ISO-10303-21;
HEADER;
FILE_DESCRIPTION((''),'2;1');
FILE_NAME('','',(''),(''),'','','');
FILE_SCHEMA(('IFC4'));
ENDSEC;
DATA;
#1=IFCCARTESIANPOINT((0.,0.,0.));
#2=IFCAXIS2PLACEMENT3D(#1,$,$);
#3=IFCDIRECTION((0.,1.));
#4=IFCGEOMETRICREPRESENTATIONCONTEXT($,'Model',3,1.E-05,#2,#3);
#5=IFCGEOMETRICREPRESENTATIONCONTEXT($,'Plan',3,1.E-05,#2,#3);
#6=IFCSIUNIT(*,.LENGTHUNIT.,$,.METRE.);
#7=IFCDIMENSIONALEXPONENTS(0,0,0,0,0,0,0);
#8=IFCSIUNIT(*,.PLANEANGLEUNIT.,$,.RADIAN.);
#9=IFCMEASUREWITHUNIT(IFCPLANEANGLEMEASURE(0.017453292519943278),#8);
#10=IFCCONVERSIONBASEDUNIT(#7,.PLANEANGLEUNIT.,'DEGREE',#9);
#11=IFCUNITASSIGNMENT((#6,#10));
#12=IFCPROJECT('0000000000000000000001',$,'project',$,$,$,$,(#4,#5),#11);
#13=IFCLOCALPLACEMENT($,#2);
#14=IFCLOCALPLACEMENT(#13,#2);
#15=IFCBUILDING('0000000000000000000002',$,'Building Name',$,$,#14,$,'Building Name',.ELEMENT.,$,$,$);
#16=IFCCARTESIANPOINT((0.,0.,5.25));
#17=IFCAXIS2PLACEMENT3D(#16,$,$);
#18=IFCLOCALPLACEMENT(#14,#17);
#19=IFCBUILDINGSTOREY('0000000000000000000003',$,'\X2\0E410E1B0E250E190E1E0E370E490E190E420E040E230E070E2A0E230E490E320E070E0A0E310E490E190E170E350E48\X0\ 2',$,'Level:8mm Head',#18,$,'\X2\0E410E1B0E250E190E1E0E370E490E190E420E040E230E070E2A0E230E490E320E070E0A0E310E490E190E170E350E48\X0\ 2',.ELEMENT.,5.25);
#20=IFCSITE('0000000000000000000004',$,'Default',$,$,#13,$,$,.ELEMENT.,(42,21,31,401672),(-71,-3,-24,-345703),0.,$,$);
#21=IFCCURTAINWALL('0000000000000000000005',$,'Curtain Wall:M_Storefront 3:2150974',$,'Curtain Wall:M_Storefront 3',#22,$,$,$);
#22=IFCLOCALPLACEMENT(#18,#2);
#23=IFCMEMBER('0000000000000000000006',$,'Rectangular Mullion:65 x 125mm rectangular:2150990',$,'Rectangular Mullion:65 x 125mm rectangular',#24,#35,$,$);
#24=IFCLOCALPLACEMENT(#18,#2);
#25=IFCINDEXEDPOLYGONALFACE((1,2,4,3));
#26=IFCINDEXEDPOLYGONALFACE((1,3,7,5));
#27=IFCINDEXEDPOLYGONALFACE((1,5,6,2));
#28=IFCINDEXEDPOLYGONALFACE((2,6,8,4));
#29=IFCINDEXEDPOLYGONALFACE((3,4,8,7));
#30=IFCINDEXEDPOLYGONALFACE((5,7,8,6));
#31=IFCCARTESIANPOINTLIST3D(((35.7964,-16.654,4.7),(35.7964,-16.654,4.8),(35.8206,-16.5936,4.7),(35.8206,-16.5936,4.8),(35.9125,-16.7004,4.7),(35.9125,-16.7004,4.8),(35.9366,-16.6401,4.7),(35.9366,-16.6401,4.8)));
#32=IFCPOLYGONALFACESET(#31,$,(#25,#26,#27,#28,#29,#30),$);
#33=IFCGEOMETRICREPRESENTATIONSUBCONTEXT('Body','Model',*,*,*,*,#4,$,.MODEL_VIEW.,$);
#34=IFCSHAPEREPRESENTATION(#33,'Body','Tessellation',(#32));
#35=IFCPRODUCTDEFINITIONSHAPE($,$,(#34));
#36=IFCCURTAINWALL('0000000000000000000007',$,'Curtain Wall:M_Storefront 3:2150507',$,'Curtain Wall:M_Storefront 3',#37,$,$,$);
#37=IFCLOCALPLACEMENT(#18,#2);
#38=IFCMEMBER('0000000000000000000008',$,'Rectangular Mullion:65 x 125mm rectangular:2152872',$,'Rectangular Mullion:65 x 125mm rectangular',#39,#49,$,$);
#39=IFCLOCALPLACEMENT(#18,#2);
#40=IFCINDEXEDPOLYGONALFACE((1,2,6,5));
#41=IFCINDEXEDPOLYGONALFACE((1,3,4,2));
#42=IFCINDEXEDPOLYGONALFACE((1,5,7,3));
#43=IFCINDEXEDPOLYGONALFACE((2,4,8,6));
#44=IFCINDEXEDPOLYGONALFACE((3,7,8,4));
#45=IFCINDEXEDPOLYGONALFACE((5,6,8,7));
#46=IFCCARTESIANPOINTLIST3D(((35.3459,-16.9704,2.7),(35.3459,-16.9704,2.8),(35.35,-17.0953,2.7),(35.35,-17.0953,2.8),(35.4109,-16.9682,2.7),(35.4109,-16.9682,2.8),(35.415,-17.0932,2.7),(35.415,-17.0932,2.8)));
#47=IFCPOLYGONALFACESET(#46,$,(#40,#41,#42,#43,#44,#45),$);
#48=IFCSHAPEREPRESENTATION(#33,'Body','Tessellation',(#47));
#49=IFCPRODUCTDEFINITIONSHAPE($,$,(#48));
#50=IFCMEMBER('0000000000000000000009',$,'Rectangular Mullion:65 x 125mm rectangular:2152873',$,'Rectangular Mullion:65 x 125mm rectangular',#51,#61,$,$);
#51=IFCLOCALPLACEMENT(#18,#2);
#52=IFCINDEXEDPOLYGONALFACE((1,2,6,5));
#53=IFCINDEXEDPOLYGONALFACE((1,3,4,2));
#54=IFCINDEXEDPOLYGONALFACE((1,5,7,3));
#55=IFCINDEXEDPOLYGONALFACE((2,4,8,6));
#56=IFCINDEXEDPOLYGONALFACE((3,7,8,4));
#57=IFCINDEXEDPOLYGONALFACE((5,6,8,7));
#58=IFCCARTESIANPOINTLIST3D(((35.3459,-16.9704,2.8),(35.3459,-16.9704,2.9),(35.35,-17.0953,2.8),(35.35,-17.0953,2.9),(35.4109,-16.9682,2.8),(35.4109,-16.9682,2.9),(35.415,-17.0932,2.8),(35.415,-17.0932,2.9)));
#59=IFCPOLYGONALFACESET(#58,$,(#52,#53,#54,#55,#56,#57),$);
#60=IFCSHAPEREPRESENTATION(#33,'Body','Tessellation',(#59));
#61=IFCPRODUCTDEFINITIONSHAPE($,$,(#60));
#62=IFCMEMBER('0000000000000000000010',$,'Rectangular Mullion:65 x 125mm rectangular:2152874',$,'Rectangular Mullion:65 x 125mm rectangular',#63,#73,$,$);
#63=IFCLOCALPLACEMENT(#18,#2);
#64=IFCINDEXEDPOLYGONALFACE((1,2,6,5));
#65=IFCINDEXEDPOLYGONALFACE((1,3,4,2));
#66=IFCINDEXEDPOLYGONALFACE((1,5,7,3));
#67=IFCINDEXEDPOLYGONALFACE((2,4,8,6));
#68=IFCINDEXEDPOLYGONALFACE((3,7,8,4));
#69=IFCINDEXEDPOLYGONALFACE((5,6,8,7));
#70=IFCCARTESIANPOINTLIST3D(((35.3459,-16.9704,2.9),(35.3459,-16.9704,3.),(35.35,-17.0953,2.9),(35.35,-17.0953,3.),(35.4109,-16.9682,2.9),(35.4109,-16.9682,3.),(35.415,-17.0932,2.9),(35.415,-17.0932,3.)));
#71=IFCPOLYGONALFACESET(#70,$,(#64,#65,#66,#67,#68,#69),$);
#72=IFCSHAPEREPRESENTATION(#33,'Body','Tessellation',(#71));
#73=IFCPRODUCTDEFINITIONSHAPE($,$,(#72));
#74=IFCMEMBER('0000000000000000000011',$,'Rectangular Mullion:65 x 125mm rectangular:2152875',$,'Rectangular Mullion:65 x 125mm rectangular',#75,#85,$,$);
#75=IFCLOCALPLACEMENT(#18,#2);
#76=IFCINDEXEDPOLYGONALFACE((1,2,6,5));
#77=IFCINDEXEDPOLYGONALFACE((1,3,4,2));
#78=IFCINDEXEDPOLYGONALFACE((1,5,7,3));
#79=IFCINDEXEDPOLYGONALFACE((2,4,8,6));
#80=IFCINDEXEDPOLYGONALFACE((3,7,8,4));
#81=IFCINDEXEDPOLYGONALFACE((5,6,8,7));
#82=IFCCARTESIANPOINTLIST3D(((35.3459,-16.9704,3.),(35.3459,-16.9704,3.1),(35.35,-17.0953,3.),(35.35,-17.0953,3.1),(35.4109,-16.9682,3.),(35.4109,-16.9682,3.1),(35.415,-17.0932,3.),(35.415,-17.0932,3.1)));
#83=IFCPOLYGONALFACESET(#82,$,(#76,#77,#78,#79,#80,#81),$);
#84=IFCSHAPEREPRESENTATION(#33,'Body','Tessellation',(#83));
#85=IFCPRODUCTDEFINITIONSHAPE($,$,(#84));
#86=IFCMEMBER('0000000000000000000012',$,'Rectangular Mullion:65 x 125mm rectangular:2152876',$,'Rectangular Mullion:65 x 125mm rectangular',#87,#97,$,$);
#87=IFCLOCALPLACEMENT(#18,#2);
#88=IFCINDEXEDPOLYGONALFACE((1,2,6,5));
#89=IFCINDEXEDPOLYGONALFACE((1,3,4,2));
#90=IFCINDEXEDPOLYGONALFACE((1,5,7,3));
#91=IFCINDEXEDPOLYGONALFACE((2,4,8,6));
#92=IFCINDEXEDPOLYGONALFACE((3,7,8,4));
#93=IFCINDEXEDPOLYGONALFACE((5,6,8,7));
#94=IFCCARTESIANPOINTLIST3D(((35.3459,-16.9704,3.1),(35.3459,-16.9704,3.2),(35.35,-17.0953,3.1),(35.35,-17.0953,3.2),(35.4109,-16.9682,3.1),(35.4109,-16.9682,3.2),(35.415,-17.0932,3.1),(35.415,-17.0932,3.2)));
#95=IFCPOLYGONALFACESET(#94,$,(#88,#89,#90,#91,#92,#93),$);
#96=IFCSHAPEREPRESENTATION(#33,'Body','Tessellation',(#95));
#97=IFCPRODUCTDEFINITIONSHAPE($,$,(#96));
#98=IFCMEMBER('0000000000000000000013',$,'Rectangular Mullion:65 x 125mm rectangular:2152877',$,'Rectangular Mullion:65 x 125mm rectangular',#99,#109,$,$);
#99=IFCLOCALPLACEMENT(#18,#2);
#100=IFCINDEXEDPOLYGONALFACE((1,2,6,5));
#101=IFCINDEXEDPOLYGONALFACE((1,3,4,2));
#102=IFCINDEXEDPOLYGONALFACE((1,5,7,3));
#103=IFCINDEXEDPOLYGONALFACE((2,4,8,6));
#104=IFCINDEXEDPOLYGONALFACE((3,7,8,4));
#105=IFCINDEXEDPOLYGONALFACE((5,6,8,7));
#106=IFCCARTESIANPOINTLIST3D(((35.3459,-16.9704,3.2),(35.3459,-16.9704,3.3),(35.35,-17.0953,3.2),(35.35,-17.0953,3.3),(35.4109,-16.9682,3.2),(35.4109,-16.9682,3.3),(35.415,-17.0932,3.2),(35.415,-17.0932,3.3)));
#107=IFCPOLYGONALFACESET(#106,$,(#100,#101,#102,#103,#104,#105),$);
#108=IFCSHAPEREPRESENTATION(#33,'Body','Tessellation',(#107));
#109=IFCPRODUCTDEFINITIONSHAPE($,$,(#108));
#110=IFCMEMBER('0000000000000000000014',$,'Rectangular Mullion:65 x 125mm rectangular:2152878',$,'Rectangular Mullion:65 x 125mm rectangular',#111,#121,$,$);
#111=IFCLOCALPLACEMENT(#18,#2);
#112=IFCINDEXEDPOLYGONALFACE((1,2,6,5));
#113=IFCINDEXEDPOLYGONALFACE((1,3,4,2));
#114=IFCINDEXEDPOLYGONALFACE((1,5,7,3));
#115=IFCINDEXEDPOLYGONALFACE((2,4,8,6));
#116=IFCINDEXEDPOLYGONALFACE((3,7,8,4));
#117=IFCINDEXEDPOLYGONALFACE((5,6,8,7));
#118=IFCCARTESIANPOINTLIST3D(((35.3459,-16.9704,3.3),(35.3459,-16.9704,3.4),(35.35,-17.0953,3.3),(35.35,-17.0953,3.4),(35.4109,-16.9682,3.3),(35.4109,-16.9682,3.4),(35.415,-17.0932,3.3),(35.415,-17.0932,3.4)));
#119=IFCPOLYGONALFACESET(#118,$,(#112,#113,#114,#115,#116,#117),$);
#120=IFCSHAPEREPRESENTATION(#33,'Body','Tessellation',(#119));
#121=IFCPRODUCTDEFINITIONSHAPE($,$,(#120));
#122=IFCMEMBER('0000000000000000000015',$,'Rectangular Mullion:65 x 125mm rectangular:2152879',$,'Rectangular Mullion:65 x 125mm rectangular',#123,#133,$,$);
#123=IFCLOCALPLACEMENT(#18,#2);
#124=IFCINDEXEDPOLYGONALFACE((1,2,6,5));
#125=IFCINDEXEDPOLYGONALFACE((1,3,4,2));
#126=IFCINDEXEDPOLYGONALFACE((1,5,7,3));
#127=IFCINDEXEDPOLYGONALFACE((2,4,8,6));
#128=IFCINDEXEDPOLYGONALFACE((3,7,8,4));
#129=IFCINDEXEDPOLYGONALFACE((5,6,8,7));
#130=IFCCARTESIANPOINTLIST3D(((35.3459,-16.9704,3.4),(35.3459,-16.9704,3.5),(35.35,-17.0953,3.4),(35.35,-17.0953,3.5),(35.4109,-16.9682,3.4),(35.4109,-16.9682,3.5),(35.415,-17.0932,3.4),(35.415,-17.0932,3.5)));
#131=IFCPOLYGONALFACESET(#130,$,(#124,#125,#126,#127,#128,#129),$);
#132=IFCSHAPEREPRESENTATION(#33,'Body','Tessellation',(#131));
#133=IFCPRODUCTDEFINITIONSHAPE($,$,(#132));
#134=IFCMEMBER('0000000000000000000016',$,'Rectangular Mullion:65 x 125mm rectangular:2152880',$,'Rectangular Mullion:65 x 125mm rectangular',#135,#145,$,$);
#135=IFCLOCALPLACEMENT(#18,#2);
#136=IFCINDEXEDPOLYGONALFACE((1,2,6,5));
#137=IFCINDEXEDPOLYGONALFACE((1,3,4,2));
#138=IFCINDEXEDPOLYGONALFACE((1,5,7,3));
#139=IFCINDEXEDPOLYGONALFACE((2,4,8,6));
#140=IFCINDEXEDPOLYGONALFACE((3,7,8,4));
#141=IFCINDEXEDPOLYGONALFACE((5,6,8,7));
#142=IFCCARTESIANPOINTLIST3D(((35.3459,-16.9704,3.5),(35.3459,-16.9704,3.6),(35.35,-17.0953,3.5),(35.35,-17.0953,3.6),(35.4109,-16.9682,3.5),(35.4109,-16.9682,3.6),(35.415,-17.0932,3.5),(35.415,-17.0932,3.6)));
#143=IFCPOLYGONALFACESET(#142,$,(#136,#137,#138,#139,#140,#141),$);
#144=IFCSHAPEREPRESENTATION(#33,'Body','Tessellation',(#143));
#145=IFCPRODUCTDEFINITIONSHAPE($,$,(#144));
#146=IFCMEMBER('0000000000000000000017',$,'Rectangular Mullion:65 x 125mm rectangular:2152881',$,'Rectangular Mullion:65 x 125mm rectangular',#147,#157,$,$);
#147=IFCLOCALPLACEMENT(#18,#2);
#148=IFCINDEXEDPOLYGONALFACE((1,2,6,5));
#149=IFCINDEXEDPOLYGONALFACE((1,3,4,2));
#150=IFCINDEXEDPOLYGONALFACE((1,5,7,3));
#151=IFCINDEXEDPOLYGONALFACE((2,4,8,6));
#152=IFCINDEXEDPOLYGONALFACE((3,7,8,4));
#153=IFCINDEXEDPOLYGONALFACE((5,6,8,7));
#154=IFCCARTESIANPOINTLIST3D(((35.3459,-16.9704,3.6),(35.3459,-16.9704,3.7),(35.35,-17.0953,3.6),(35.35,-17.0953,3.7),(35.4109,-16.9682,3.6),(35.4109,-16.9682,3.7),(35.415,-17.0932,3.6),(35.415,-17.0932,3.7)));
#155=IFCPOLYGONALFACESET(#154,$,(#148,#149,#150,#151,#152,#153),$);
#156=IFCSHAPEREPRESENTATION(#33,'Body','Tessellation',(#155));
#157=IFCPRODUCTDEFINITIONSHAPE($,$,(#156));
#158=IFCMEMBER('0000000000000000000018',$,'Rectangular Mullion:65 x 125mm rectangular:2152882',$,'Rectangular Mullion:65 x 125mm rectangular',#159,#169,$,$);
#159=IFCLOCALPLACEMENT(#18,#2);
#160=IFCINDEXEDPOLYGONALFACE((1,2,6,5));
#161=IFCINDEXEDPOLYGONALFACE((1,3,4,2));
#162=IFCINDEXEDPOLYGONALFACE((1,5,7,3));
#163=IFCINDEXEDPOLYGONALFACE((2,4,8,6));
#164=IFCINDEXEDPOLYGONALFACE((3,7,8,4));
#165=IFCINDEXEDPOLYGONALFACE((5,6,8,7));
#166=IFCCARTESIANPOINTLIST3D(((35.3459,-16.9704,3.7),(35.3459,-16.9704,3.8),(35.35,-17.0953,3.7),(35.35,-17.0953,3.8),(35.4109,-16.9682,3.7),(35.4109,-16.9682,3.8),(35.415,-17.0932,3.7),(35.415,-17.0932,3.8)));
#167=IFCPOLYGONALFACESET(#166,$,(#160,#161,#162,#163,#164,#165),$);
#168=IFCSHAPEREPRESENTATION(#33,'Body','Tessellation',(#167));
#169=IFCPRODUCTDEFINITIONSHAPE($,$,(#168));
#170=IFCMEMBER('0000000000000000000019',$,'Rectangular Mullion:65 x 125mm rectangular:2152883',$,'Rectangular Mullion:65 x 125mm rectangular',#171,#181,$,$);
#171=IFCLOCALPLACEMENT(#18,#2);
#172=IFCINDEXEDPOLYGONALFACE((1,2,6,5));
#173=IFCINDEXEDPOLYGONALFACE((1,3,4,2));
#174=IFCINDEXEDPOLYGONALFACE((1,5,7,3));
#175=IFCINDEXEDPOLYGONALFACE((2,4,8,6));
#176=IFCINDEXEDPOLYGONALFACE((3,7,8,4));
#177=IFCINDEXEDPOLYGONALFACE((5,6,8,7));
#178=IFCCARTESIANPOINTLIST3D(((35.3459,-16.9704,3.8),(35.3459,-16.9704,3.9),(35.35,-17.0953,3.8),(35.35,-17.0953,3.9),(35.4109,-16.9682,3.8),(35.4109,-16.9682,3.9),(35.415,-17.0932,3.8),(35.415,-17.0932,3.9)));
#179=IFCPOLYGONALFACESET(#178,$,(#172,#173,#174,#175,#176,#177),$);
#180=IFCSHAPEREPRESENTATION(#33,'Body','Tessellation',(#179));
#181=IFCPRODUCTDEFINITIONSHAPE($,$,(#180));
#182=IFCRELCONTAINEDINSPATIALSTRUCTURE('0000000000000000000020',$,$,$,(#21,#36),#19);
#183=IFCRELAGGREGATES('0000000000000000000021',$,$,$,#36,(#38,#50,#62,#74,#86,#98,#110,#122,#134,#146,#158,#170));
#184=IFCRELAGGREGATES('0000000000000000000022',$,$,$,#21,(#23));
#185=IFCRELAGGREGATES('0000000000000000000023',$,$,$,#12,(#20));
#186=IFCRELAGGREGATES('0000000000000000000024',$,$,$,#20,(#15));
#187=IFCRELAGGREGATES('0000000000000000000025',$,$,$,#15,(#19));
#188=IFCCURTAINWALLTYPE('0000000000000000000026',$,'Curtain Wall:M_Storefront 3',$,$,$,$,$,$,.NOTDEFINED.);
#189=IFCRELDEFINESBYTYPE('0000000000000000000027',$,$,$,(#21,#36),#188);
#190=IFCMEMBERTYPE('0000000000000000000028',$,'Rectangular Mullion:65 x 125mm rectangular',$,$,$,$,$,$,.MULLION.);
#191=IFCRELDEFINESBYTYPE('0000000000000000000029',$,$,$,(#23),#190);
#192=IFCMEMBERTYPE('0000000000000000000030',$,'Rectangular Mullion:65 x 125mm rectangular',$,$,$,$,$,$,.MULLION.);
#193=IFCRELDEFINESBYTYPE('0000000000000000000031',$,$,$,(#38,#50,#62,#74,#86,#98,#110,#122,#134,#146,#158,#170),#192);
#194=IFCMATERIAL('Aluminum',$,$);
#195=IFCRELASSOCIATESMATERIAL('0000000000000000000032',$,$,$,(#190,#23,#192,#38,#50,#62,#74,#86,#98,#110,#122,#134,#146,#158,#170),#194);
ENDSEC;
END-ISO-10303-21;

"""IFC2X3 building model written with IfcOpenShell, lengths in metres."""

from ifc_helpers import new_model, entity, si_unit, converted_unit, direction, frame, origin, origin_2d_with_axis, place, context, subcontext, project, spatial, rectangle, extrude, source, transform, mapped, material, type_object, type_shapes, element, aggregate, save


model = new_model("IFC2X3")

# Units and contexts
model_context = context("Model", 3, precision=1e-05, world=origin(), true_north=direction((0.0, 1.0)))
plan_context = context("Plan", 3, precision=1e-05, world=origin(), true_north=direction((0.0, 1.0)))
body_context = subcontext(model_context, "Body", "Model", "MODEL_VIEW")
ifc_project = project(units=[si_unit("LENGTHUNIT", "METRE"), converted_unit("PLANEANGLEUNIT", "DEGREE", entity("IfcPlaneAngleMeasure", 0.017453292519943278), si_unit("PLANEANGLEUNIT", "RADIAN"), dimensions=[0, 0, 0, 0, 0, 0, 0])], contexts=[model_context, plan_context])

# Site, building, storey
site_placement = place(None, origin())
site = spatial("IfcSite", under=ifc_project, at=site_placement, Name="Default", CompositionType="ELEMENT", RefLatitude=(42, 21, 31, 401672), RefLongitude=(-71, -3, -24, -345703), RefElevation=0.0)
building_placement = place(site_placement, origin())
building = spatial("IfcBuilding", under=site, at=building_placement, Name="Building Name", LongName="Building Name", CompositionType="ELEMENT")
storey_placement = place(building_placement, frame((0.0, 0.0, 5.25)))
storey = spatial("IfcBuildingStorey", under=building, at=storey_placement, Name="แปลนพื้นโครงสร้างชั้นที่ 2", ObjectType="Level:8mm Head", LongName="แปลนพื้นโครงสร้างชั้นที่ 2", CompositionType="ELEMENT", Elevation=5.25)

# Curtain wall, member
curtain_wall_type = type_object("IfcCurtainWallType", Name="Curtain Wall:M_Storefront 3", PredefinedType="NOTDEFINED")
curtain_wall_1_placement = place(storey_placement, frame((0.0, 0.0, -5.25)))
curtain_wall_1 = element("IfcCurtainWall", 1, at=curtain_wall_1_placement, inside=storey, type_object=curtain_wall_type, Name="Curtain Wall:M_Storefront 3:2150974", ObjectType="Curtain Wall:M_Storefront 3")
ifc_material = material(Name="Aluminum")
member_type_1 = type_object("IfcMemberType", Name="Rectangular Mullion:65 x 125mm rectangular", PredefinedType="MULLION", material=ifc_material)
shared_shape_1 = source(origin(), body_context, "Body", "SweptSolid", [
    extrude(rectangle(XDim=0.065, YDim=0.125, at=origin_2d_with_axis()), frame((-0.0325, 0.0, -0.1), z_axis=(0.0, 0.0, 1.0), x_axis=(-1.0, 0.0, 0.0)), (0.0, 0.0, 1.0), 0.1),
])
type_shapes(member_type_1, [shared_shape_1])
member_1_placement = place(curtain_wall_1_placement, frame((35.8545, -16.6772, 10.05), z_axis=(0.0, 0.0, 1.0), x_axis=(-0.371573, -0.928404, 0.0)))
member_1 = element("IfcMember", 2, at=member_1_placement, type_object=member_type_1, material=ifc_material, Name="Rectangular Mullion:65 x 125mm rectangular:2150990", ObjectType="Rectangular Mullion:65 x 125mm rectangular", context=body_context, shape_type="MappedRepresentation", body=[
    mapped(shared_shape_1, transform((0.0, 0.0, 0.0), scale=1.0)),
])

# Curtain wall, members
curtain_wall_2_placement = place(storey_placement, frame((0.0, 0.0, -5.25)))
curtain_wall_2 = element("IfcCurtainWall", 3, at=curtain_wall_2_placement, inside=storey, type_object=curtain_wall_type, Name="Curtain Wall:M_Storefront 3:2150507", ObjectType="Curtain Wall:M_Storefront 3")
member_type_2 = type_object("IfcMemberType", Name="Rectangular Mullion:65 x 125mm rectangular", PredefinedType="MULLION", material=ifc_material)
shared_shape_2 = source(origin(), body_context, "Body", "SweptSolid", [
    extrude(rectangle(XDim=0.065, YDim=0.125, at=origin_2d_with_axis()), frame((-0.0325, 0.0, -0.1), z_axis=(0.0, 0.0, 1.0), x_axis=(-1.0, 0.0, 0.0)), (0.0, 0.0, 1.0), 0.1),
])
type_shapes(member_type_2, [shared_shape_2])
member_2_placement = place(curtain_wall_2_placement, frame((35.4129, -17.0307, 7.95), z_axis=(0.0, 0.0, -1.0), x_axis=(0.99946, 0.032862, 0.0)))
member_2 = element("IfcMember", 4, at=member_2_placement, type_object=member_type_2, material=ifc_material, Name="Rectangular Mullion:65 x 125mm rectangular:2152872", ObjectType="Rectangular Mullion:65 x 125mm rectangular", context=body_context, shape_type="MappedRepresentation", body=[
    mapped(shared_shape_2, transform((0.0, 0.0, 0.0), scale=1.0)),
])
member_3_placement = place(curtain_wall_2_placement, frame((35.4129, -17.0307, 8.05), z_axis=(0.0, 0.0, -1.0), x_axis=(0.99946, 0.032862, 0.0)))
member_3 = element("IfcMember", 5, at=member_3_placement, type_object=member_type_2, material=ifc_material, Name="Rectangular Mullion:65 x 125mm rectangular:2152873", ObjectType="Rectangular Mullion:65 x 125mm rectangular", context=body_context, shape_type="MappedRepresentation", body=[
    mapped(shared_shape_2, transform((0.0, 0.0, 0.0), scale=1.0)),
])
member_4_placement = place(curtain_wall_2_placement, frame((35.4129, -17.0307, 8.15), z_axis=(0.0, 0.0, -1.0), x_axis=(0.99946, 0.032862, 0.0)))
member_4 = element("IfcMember", 6, at=member_4_placement, type_object=member_type_2, material=ifc_material, Name="Rectangular Mullion:65 x 125mm rectangular:2152874", ObjectType="Rectangular Mullion:65 x 125mm rectangular", context=body_context, shape_type="MappedRepresentation", body=[
    mapped(shared_shape_2, transform((0.0, 0.0, 0.0), scale=1.0)),
])
member_5_placement = place(curtain_wall_2_placement, frame((35.4129, -17.0307, 8.25), z_axis=(0.0, 0.0, -1.0), x_axis=(0.99946, 0.032862, 0.0)))
member_5 = element("IfcMember", 7, at=member_5_placement, type_object=member_type_2, material=ifc_material, Name="Rectangular Mullion:65 x 125mm rectangular:2152875", ObjectType="Rectangular Mullion:65 x 125mm rectangular", context=body_context, shape_type="MappedRepresentation", body=[
    mapped(shared_shape_2, transform((0.0, 0.0, 0.0), scale=1.0)),
])
member_6_placement = place(curtain_wall_2_placement, frame((35.4129, -17.0307, 8.35), z_axis=(0.0, 0.0, -1.0), x_axis=(0.99946, 0.032862, 0.0)))
member_6 = element("IfcMember", 8, at=member_6_placement, type_object=member_type_2, material=ifc_material, Name="Rectangular Mullion:65 x 125mm rectangular:2152876", ObjectType="Rectangular Mullion:65 x 125mm rectangular", context=body_context, shape_type="MappedRepresentation", body=[
    mapped(shared_shape_2, transform((0.0, 0.0, 0.0), scale=1.0)),
])
member_7_placement = place(curtain_wall_2_placement, frame((35.4129, -17.0307, 8.45), z_axis=(0.0, 0.0, -1.0), x_axis=(0.99946, 0.032862, 0.0)))
member_7 = element("IfcMember", 9, at=member_7_placement, type_object=member_type_2, material=ifc_material, Name="Rectangular Mullion:65 x 125mm rectangular:2152877", ObjectType="Rectangular Mullion:65 x 125mm rectangular", context=body_context, shape_type="MappedRepresentation", body=[
    mapped(shared_shape_2, transform((0.0, 0.0, 0.0), scale=1.0)),
])
member_8_placement = place(curtain_wall_2_placement, frame((35.4129, -17.0307, 8.55), z_axis=(0.0, 0.0, -1.0), x_axis=(0.99946, 0.032862, 0.0)))
member_8 = element("IfcMember", 10, at=member_8_placement, type_object=member_type_2, material=ifc_material, Name="Rectangular Mullion:65 x 125mm rectangular:2152878", ObjectType="Rectangular Mullion:65 x 125mm rectangular", context=body_context, shape_type="MappedRepresentation", body=[
    mapped(shared_shape_2, transform((0.0, 0.0, 0.0), scale=1.0)),
])
member_9_placement = place(curtain_wall_2_placement, frame((35.4129, -17.0307, 8.65), z_axis=(0.0, 0.0, -1.0), x_axis=(0.99946, 0.032862, 0.0)))
member_9 = element("IfcMember", 11, at=member_9_placement, type_object=member_type_2, material=ifc_material, Name="Rectangular Mullion:65 x 125mm rectangular:2152879", ObjectType="Rectangular Mullion:65 x 125mm rectangular", context=body_context, shape_type="MappedRepresentation", body=[
    mapped(shared_shape_2, transform((0.0, 0.0, 0.0), scale=1.0)),
])
member_10_placement = place(curtain_wall_2_placement, frame((35.4129, -17.0307, 8.75), z_axis=(0.0, 0.0, -1.0), x_axis=(0.99946, 0.032862, 0.0)))
member_10 = element("IfcMember", 12, at=member_10_placement, type_object=member_type_2, material=ifc_material, Name="Rectangular Mullion:65 x 125mm rectangular:2152880", ObjectType="Rectangular Mullion:65 x 125mm rectangular", context=body_context, shape_type="MappedRepresentation", body=[
    mapped(shared_shape_2, transform((0.0, 0.0, 0.0), scale=1.0)),
])
member_11_placement = place(curtain_wall_2_placement, frame((35.4129, -17.0307, 8.85), z_axis=(0.0, 0.0, -1.0), x_axis=(0.99946, 0.032862, 0.0)))
member_11 = element("IfcMember", 13, at=member_11_placement, type_object=member_type_2, material=ifc_material, Name="Rectangular Mullion:65 x 125mm rectangular:2152881", ObjectType="Rectangular Mullion:65 x 125mm rectangular", context=body_context, shape_type="MappedRepresentation", body=[
    mapped(shared_shape_2, transform((0.0, 0.0, 0.0), scale=1.0)),
])
member_12_placement = place(curtain_wall_2_placement, frame((35.4129, -17.0307, 8.95), z_axis=(0.0, 0.0, -1.0), x_axis=(0.99946, 0.032862, 0.0)))
member_12 = element("IfcMember", 14, at=member_12_placement, type_object=member_type_2, material=ifc_material, Name="Rectangular Mullion:65 x 125mm rectangular:2152882", ObjectType="Rectangular Mullion:65 x 125mm rectangular", context=body_context, shape_type="MappedRepresentation", body=[
    mapped(shared_shape_2, transform((0.0, 0.0, 0.0), scale=1.0)),
])
member_13_placement = place(curtain_wall_2_placement, frame((35.4129, -17.0307, 9.05), z_axis=(0.0, 0.0, -1.0), x_axis=(0.99946, 0.032862, 0.0)))
member_13 = element("IfcMember", 15, at=member_13_placement, type_object=member_type_2, material=ifc_material, Name="Rectangular Mullion:65 x 125mm rectangular:2152883", ObjectType="Rectangular Mullion:65 x 125mm rectangular", context=body_context, shape_type="MappedRepresentation", body=[
    mapped(shared_shape_2, transform((0.0, 0.0, 0.0), scale=1.0)),
])
aggregate(curtain_wall_2, [member_2, member_3, member_4, member_5, member_6, member_7, member_8, member_9, member_10, member_11, member_12, member_13])

aggregate(curtain_wall_1, [member_1])

save(model, "model.ifc")
